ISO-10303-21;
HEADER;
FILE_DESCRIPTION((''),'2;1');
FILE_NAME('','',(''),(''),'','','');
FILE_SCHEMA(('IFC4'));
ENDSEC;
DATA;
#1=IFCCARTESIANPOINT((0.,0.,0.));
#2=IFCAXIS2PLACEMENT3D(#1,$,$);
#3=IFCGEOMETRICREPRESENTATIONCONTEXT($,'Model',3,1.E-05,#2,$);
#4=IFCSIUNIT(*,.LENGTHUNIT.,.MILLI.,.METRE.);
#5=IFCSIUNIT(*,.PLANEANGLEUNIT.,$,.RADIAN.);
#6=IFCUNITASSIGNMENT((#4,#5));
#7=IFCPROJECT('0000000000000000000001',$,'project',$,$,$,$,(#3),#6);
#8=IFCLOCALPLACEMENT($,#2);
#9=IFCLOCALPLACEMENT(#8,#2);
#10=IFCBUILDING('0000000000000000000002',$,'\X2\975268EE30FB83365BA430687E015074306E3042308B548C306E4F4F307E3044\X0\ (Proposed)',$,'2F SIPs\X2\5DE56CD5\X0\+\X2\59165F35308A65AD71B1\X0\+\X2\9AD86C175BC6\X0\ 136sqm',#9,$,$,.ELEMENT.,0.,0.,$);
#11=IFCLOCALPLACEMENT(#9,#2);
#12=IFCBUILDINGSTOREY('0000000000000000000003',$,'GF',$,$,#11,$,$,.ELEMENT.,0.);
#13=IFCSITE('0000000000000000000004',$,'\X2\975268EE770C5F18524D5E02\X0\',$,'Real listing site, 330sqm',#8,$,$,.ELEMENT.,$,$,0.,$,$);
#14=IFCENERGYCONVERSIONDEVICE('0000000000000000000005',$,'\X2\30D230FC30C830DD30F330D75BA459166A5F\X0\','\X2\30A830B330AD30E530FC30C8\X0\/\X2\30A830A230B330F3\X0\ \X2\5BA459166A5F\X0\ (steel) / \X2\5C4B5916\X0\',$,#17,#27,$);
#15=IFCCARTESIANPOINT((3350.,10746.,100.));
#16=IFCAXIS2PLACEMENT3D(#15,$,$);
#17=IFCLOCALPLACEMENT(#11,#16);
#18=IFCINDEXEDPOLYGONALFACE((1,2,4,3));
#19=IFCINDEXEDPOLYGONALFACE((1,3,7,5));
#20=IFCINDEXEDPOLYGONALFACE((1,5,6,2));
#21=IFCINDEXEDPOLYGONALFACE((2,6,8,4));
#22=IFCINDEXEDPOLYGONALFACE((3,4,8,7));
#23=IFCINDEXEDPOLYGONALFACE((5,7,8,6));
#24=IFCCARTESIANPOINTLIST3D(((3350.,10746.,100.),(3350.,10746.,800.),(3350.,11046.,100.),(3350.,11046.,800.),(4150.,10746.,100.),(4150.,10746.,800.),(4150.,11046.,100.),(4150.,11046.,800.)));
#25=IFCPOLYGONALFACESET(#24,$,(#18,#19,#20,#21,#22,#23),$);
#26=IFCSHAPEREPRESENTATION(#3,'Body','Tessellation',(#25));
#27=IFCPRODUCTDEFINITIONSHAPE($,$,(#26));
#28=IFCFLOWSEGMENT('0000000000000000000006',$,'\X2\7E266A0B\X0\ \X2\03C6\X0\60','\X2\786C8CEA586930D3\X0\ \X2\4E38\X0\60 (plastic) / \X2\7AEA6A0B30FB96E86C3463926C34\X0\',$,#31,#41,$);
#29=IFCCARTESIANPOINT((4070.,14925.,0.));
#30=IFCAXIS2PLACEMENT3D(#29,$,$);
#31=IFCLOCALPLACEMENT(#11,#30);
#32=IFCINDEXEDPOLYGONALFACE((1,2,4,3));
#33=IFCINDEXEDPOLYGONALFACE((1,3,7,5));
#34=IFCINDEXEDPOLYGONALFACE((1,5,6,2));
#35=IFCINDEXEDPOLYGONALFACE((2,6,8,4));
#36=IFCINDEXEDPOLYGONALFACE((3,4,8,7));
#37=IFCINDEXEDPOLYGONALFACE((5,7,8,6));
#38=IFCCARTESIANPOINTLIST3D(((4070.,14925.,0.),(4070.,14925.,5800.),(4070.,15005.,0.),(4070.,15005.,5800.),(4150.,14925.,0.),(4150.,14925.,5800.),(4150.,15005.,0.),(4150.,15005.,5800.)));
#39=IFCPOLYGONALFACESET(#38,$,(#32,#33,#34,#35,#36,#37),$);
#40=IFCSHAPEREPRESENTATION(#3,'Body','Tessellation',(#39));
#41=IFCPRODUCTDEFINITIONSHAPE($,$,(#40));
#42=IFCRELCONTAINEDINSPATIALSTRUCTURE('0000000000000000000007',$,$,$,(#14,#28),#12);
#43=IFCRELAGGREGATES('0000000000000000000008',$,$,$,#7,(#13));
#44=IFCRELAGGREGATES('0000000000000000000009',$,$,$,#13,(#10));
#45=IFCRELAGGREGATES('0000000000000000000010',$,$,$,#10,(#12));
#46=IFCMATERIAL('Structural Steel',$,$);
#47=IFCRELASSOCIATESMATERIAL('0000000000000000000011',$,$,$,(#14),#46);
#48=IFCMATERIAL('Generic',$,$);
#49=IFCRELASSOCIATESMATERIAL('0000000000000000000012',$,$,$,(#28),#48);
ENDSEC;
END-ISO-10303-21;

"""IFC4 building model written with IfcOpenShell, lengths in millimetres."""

from ifc_helpers import new_model, si_unit, frame, frame_2d, origin, place, context, project, spatial, rectangle, extrude, material, element, save


model = new_model("IFC4")

# Units and contexts
model_context = context("Model", 3, precision=1e-05, world=origin())
ifc_project = project(units=[si_unit("LENGTHUNIT", "METRE", prefix="MILLI"), si_unit("PLANEANGLEUNIT", "RADIAN")], contexts=[model_context])

# Site, building, storey
site_placement = place(None, origin())
site = spatial("IfcSite", under=ifc_project, at=site_placement, Name="青森県弘前市", ObjectType="Real listing site, 330sqm", CompositionType="ELEMENT", RefElevation=0.0)
building_placement = place(site_placement, origin())
building = spatial("IfcBuilding", under=site, at=building_placement, Name="青森・茶室と縁側のある和の住まい (Proposed)", ObjectType="2F SIPs工法+外張り断熱+高気密 136sqm", CompositionType="ELEMENT", ElevationOfRefHeight=0.0, ElevationOfTerrain=0.0)
storey_placement = place(building_placement, origin())
storey = spatial("IfcBuildingStorey", under=building, at=storey_placement, Name="GF", CompositionType="ELEMENT", Elevation=0.0)

# Shared definitions
ifc_material_1 = material(Name="Generic")

# Energy conversion device
ifc_material_2 = material(Name="Structural Steel")
energy_conversion_device_placement = place(storey_placement, frame((3350.0, 10746.0, 100.0)))
element("IfcEnergyConversionDevice", 1, at=energy_conversion_device_placement, inside=storey, material=ifc_material_2, Name="ヒートポンプ室外機", Description="エコキュート/エアコン 室外機 (steel) / 屋外", context=model_context, shape_type="SweptSolid", body=[
    extrude(rectangle(XDim=800.0, YDim=300.0, at=frame_2d((400.0, 150.0))), frame((3350.0, 10746.0, 100.0)), (0.0, 0.0, 1.0), 700.0),
])

# Flow segment
flow_segment_placement = place(storey_placement, frame((4070.0, 14925.0, 0.0)))
element("IfcFlowSegment", 2, at=flow_segment_placement, inside=storey, material=ifc_material_1, Name="縦樋 φ60", Description="硬質塩ビ 丸60 (plastic) / 竪樋・雨水排水", context=model_context, shape_type="SweptSolid", body=[
    extrude(rectangle(XDim=80.0, YDim=80.0, at=frame_2d((40.0, 40.0))), frame((4070.0, 14925.0, 0.0)), (0.0, 0.0, 1.0), 5800.0),
])

save(model, "model.ifc")
